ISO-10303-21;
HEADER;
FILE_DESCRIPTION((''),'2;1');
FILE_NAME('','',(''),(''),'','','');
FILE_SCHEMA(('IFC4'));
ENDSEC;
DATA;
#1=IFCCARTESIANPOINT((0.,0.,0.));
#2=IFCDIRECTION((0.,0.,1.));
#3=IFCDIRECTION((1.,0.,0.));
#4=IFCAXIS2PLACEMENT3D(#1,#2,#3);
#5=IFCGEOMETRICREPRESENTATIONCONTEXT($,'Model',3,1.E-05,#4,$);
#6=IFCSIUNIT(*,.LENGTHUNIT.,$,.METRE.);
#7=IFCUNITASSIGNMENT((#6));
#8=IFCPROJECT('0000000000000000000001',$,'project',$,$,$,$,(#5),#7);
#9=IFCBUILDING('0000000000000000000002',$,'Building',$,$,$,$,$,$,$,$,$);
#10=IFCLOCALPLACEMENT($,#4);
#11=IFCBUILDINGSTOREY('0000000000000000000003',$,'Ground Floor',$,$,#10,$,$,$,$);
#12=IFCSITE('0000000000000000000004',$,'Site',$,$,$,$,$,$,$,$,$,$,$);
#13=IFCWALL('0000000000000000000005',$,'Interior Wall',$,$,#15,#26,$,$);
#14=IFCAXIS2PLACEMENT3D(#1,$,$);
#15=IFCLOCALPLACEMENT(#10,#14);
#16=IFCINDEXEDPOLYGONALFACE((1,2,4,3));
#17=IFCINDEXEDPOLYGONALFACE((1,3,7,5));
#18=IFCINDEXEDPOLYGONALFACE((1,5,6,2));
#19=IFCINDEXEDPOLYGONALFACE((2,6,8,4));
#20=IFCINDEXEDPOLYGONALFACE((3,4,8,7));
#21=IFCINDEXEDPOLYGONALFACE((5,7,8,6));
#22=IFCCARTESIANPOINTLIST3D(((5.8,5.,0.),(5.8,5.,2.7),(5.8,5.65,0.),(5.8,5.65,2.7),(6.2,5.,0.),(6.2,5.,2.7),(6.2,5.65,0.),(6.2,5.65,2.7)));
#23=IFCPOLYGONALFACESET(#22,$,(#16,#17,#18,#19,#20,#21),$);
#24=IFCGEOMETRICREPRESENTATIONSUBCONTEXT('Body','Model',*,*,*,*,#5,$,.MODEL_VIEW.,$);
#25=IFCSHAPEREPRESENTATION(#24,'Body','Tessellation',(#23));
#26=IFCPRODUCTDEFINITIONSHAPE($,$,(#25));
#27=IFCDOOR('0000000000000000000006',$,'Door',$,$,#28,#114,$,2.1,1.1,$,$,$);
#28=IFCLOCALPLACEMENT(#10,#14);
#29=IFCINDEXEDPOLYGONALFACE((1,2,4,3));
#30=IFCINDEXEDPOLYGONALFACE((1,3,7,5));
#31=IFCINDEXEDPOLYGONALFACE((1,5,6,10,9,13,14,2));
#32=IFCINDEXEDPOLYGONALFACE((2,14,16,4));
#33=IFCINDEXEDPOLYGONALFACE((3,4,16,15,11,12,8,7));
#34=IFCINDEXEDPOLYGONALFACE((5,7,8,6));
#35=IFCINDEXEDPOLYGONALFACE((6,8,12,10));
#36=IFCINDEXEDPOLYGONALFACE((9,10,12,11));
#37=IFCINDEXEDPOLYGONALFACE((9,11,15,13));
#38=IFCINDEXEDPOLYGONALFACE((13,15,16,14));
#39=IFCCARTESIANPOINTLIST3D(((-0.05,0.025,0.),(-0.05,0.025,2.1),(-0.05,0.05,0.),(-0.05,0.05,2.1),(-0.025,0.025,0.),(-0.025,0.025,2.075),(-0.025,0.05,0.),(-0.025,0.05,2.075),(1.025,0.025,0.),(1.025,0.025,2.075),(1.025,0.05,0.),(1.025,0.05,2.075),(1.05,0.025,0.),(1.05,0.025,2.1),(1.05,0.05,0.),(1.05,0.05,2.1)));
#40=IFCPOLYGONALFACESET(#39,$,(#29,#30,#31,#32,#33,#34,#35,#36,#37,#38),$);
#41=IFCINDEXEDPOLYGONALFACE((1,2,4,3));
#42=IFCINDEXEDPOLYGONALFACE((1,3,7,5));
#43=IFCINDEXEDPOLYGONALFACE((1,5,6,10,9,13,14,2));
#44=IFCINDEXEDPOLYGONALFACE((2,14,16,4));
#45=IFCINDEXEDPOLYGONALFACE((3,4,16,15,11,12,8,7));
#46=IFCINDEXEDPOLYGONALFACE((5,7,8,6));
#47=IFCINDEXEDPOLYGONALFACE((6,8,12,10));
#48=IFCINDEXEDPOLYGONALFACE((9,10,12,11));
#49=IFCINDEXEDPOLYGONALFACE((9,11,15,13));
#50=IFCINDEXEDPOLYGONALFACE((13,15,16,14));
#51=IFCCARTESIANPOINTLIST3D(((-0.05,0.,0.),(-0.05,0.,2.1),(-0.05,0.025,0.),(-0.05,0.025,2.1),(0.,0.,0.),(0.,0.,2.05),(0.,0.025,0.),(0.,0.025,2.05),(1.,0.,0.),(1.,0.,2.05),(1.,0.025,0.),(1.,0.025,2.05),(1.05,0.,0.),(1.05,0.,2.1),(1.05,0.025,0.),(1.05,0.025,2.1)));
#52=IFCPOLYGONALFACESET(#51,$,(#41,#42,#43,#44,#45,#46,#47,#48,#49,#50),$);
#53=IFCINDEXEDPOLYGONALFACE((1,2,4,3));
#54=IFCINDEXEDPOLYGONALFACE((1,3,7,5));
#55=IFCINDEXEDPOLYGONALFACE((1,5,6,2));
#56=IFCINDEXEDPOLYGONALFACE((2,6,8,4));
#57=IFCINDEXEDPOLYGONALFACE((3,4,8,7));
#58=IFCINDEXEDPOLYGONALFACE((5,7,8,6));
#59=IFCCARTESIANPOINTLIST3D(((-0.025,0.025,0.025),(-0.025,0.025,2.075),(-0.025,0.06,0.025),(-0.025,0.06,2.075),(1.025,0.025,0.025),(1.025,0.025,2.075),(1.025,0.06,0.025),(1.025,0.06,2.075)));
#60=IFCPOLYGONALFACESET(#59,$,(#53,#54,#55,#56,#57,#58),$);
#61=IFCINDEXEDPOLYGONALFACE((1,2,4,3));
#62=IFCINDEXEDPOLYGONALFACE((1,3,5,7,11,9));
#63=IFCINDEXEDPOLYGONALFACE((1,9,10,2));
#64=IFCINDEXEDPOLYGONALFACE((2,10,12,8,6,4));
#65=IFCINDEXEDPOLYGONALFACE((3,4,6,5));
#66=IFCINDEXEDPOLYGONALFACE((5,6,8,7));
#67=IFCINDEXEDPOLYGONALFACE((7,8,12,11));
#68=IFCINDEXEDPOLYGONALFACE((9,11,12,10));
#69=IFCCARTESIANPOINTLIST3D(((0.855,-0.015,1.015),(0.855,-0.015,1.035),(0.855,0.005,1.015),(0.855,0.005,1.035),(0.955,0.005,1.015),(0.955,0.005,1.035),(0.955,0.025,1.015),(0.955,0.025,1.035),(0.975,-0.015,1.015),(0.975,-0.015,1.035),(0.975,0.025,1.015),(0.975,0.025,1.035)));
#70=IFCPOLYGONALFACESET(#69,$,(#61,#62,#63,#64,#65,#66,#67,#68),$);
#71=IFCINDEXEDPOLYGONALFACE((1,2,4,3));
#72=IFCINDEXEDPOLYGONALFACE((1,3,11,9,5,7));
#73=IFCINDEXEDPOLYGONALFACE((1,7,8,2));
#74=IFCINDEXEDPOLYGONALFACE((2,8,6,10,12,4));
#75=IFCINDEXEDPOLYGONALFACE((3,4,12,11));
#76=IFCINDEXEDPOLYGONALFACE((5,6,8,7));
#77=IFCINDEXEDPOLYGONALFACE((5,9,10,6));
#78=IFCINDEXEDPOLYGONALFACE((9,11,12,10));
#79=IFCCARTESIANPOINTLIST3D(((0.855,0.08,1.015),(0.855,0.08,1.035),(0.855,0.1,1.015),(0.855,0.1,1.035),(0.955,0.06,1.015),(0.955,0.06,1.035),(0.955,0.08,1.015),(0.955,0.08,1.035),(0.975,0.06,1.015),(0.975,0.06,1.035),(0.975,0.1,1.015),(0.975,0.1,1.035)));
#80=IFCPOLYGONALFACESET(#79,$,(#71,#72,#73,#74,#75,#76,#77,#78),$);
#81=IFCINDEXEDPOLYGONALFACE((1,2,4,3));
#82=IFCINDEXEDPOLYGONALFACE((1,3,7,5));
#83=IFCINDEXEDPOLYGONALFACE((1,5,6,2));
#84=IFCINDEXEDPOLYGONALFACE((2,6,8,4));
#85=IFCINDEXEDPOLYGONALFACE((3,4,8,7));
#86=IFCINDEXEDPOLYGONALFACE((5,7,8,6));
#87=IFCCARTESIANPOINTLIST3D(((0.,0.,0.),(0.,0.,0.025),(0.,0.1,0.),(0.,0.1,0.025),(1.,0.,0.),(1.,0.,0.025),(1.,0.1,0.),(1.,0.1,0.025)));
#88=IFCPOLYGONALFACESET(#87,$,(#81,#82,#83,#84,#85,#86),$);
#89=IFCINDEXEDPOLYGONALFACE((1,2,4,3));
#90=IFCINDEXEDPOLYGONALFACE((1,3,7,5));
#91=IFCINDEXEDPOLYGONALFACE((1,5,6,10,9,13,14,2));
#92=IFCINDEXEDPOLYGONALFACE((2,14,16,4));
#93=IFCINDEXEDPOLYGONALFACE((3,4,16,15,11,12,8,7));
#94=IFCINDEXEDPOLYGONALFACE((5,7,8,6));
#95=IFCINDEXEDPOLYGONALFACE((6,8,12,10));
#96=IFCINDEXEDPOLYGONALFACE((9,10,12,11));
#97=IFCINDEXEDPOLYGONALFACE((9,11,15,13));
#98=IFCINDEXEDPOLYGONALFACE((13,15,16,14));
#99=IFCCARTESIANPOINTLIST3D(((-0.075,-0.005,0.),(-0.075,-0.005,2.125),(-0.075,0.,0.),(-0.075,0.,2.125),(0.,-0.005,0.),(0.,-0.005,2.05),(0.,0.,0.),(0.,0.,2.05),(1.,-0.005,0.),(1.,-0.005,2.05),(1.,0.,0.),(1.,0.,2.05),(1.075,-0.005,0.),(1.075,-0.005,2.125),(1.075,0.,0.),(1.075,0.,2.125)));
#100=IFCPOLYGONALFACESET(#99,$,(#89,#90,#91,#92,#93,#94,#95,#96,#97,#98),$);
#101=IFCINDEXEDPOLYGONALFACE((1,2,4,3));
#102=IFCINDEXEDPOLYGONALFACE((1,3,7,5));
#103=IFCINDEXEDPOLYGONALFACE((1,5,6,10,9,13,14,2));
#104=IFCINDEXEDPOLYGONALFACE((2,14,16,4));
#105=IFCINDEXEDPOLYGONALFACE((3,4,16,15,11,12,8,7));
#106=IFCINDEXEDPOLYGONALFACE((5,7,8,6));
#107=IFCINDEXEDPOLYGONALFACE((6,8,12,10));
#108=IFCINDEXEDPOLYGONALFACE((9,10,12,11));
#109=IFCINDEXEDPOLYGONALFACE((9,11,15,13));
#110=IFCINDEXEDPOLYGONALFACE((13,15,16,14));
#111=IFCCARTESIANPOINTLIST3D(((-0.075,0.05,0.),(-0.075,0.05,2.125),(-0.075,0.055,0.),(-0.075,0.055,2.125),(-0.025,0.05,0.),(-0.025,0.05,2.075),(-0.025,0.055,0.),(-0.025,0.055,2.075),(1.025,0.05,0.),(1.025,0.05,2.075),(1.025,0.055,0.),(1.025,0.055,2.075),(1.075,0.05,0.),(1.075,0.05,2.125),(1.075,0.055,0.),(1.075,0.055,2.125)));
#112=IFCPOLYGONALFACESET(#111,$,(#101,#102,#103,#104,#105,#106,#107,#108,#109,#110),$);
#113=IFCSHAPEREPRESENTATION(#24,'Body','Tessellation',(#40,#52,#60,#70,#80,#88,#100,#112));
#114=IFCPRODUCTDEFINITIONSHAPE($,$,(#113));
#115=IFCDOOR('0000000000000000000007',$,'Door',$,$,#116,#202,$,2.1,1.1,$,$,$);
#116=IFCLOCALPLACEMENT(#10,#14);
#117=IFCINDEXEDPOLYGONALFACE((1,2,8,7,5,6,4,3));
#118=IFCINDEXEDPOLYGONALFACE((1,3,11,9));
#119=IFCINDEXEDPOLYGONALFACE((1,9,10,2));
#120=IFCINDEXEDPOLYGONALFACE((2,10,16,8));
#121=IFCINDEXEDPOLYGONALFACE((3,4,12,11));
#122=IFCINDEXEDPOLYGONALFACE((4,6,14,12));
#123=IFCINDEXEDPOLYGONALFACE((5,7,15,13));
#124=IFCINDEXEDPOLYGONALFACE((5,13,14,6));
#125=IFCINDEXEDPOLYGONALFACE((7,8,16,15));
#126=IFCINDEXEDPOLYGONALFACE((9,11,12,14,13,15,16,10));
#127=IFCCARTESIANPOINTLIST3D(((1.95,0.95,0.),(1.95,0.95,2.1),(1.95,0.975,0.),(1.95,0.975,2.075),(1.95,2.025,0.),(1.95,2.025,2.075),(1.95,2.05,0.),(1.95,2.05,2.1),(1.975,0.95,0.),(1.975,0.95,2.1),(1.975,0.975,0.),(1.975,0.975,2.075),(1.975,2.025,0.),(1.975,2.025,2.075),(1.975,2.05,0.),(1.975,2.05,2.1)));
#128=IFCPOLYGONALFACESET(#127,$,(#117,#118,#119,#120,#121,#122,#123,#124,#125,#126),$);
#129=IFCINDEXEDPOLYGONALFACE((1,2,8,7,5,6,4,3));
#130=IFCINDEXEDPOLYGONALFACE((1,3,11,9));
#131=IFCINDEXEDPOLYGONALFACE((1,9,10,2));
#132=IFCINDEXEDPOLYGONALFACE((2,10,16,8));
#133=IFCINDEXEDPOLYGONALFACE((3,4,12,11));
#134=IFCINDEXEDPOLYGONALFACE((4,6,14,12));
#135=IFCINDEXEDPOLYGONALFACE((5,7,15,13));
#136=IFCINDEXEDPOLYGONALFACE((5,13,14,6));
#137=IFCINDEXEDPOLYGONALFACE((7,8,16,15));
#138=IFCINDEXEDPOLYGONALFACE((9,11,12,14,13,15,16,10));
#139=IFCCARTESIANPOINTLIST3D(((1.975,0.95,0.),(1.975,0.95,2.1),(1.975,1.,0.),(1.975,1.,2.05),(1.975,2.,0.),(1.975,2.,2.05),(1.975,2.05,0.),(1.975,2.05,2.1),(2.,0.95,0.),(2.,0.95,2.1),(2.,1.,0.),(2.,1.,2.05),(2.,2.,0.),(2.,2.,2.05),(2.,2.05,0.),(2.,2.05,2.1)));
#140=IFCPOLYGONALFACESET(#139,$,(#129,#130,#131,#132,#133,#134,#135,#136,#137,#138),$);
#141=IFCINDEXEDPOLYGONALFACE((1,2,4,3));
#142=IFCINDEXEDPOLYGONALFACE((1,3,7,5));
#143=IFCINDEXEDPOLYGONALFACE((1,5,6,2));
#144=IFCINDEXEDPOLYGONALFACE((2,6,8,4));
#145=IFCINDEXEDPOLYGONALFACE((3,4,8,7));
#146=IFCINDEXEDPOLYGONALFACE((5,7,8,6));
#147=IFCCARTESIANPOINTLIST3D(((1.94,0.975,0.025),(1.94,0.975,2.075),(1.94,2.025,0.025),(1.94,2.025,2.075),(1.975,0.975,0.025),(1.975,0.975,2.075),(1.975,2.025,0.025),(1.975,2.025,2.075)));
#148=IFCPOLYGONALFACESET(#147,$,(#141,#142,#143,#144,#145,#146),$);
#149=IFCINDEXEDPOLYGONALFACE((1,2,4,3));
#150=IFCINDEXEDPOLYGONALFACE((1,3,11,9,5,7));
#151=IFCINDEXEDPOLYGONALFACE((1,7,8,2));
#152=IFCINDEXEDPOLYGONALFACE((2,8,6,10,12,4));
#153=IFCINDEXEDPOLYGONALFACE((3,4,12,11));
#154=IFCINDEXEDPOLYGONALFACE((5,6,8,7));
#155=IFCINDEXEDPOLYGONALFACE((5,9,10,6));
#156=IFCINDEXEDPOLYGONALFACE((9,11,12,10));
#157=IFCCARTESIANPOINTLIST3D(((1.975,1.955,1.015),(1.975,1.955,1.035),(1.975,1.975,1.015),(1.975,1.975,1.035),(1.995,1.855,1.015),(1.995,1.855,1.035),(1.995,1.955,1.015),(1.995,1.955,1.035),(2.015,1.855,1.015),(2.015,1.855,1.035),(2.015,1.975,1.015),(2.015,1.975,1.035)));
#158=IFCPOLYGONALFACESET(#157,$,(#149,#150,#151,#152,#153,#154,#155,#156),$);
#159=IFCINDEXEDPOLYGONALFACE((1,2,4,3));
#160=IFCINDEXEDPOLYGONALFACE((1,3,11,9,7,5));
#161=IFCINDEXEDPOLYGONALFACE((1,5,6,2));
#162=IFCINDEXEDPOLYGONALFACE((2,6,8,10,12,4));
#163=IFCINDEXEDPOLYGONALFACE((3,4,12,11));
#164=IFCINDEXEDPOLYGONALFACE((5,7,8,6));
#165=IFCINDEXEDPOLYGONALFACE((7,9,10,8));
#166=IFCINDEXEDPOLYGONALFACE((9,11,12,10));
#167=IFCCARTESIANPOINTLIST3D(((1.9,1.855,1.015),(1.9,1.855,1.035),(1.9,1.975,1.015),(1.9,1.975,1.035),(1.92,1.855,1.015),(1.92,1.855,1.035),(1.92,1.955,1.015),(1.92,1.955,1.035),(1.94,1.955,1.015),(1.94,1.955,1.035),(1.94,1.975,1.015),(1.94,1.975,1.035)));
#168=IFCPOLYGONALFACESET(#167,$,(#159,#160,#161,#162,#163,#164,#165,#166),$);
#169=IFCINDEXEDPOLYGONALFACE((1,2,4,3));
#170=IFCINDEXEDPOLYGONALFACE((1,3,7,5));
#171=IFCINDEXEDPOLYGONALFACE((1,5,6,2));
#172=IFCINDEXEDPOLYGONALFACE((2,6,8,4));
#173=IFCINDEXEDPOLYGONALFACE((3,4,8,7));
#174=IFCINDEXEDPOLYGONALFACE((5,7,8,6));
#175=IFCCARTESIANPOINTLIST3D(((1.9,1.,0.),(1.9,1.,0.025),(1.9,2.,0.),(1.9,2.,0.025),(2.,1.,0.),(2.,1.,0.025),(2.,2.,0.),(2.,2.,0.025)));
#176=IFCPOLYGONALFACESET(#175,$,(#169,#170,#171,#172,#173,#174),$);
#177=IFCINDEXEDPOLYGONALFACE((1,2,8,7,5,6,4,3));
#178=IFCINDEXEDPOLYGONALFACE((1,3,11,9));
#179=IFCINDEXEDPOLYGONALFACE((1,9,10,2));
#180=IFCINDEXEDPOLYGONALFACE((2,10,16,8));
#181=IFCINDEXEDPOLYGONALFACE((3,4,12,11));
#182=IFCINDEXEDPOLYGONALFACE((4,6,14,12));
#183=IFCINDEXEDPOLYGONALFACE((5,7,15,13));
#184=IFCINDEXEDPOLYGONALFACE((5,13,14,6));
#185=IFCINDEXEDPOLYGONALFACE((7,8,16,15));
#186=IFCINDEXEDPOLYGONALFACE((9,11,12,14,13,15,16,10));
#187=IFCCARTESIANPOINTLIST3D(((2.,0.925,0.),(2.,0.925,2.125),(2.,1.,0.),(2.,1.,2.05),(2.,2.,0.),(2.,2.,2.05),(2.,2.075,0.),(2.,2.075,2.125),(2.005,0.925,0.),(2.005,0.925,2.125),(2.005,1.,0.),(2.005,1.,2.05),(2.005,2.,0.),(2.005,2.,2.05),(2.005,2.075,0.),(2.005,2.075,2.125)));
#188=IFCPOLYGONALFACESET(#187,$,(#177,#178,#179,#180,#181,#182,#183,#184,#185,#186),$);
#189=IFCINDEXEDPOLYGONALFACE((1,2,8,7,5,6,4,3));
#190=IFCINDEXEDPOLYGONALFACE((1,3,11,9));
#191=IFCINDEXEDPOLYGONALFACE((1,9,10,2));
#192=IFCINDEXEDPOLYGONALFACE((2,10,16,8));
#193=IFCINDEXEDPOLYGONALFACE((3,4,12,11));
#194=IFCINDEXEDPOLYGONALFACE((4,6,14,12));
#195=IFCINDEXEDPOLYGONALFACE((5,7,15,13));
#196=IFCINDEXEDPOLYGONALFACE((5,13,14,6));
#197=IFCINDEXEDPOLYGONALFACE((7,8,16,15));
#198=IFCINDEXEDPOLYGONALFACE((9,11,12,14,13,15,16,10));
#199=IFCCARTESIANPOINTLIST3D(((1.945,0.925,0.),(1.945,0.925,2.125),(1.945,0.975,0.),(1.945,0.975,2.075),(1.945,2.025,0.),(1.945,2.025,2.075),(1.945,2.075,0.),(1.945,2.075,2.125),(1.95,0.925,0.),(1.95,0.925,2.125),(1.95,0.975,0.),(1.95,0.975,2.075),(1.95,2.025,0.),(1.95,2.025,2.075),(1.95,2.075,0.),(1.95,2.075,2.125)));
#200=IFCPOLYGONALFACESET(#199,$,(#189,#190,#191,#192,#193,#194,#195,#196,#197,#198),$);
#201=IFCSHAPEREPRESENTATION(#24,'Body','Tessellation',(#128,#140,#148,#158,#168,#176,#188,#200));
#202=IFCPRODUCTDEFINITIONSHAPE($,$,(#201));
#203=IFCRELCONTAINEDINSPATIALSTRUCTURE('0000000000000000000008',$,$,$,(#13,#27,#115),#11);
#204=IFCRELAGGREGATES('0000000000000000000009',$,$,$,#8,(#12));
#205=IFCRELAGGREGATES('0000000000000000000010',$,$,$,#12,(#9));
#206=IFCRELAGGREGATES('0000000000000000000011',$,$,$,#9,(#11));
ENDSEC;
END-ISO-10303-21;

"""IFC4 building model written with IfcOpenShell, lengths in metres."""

from ifc_helpers import new_model, si_unit, frame, origin_with_axes, place, context, subcontext, project, spatial, line, indexed_curve, outline, extrude, element, save


model = new_model("IFC4")

# Units and contexts
model_context = context("Model", 3, precision=1e-05, world=origin_with_axes())
body_context = subcontext(model_context, "Body", "Model", "MODEL_VIEW")
ifc_project = project(units=[si_unit("LENGTHUNIT", "METRE")], contexts=[model_context])

# Site, building, storey
site = spatial("IfcSite", under=ifc_project, Name="Site")
building = spatial("IfcBuilding", under=site, Name="Building")
storey_placement = place(None, origin_with_axes())
storey = spatial("IfcBuildingStorey", under=building, at=storey_placement, Name="Ground Floor")

# Wall
wall_1_placement = place(storey_placement, frame((6.0, 5.0, 0.0), z_axis=(0.0, 0.0, 1.0), x_axis=(0.0, 1.0, 0.0)))
element("IfcWall", 1, at=wall_1_placement, inside=storey, Name="Interior Wall", context=body_context, shape_type="SweptSolid", body=[
    extrude(outline(indexed_curve([(0.0, 0.0), (0.0, 0.4), (0.65, 0.4), (0.65, 0.0), (0.0, 0.0)], self_intersect=False)), frame((0.0, -0.2, 0.0), z_axis=(0.0, 0.0, 1.0), x_axis=(1.0, 0.0, 0.0)), (0.0, 0.0, 1.0), 2.7),
])

# Doors
door_1_placement = place(storey_placement, frame((-0.05, 0.0, 0.0), z_axis=(0.0, 0.0, 1.0), x_axis=(1.0, 0.0, 0.0)))
element("IfcDoor", 2, at=door_1_placement, inside=storey, Name="Door", OverallHeight=2.1, OverallWidth=1.1, context=body_context, shape_type="SweptSolid", body=[
    extrude(outline(indexed_curve([(0.0, 0.0), (0.0, 2.1), (1.1, 2.1), (1.1, 0.0), (1.075, 0.0), (1.075, 2.075), (0.025, 2.075), (0.025, 0.0)], segments=[line(1, 2, 3, 4, 5, 6, 7, 8, 1)])), frame((0.0, 0.025, 0.0), z_axis=(0.0, -1.0, 0.0), x_axis=(1.0, 0.0, 0.0)), (0.0, 0.0, -1.0), 0.025),
    extrude(outline(indexed_curve([(0.0, 0.0), (0.0, 2.1), (1.1, 2.1), (1.1, 0.0), (1.05, 0.0), (1.05, 2.05), (0.05, 2.05), (0.05, 0.0)], segments=[line(1, 2, 3, 4, 5, 6, 7, 8, 1)])), frame((0.0, 0.0, 0.0), z_axis=(0.0, -1.0, 0.0), x_axis=(1.0, 0.0, 0.0)), (0.0, 0.0, -1.0), 0.025),
    extrude(outline(indexed_curve([(0.0, 0.0), (1.05, 0.0), (1.05, 0.035), (0.0, 0.035)], segments=[line(1, 2, 3, 4, 1)])), frame((0.025, 0.025, 0.025), z_axis=(0.0, 0.0, 1.0), x_axis=(1.0, 0.0, 0.0)), (0.0, 0.0, 1.0), 2.05),
    extrude(outline(indexed_curve([(0.0, 0.0), (0.0, -0.04), (-0.12, -0.04), (-0.12, -0.02), (-0.02, -0.02), (-0.02, 0.0)], segments=[line(1, 2, 3, 4, 5, 6, 1)])), frame((1.025, 0.025, 1.015), z_axis=(0.0, 0.0, 1.0), x_axis=(1.0, 0.0, 0.0)), (0.0, 0.0, 1.0), 0.02),
    extrude(outline(indexed_curve([(0.0, 0.0), (0.0, 0.04), (-0.12, 0.04), (-0.12, 0.02), (-0.02, 0.02), (-0.02, 0.0)], segments=[line(1, 2, 3, 4, 5, 6, 1)])), frame((1.025, 0.06, 1.015), z_axis=(0.0, 0.0, 1.0), x_axis=(1.0, 0.0, 0.0)), (0.0, 0.0, 1.0), 0.02),
    extrude(outline(indexed_curve([(0.0, 0.0), (1.0, 0.0), (1.0, 0.1), (0.0, 0.1)], segments=[line(1, 2, 3, 4, 1)])), frame((0.05, 0.0, 0.0), z_axis=(0.0, 0.0, 1.0), x_axis=(1.0, 0.0, 0.0)), (0.0, 0.0, 1.0), 0.025),
    extrude(outline(indexed_curve([(0.0, 0.0), (0.0, 2.125), (1.15, 2.125), (1.15, 0.0), (1.075, 0.0), (1.075, 2.05), (0.075, 2.05), (0.075, 0.0)], segments=[line(1, 2, 3, 4, 5, 6, 7, 8, 1)])), frame((-0.025, -0.005, 0.0), z_axis=(0.0, -1.0, 0.0), x_axis=(1.0, 0.0, 0.0)), (0.0, 0.0, -1.0), 0.005),
    extrude(outline(indexed_curve([(0.0, 0.0), (0.0, 2.125), (1.15, 2.125), (1.15, 0.0), (1.1, 0.0), (1.1, 2.075), (0.05, 2.075), (0.05, 0.0)], segments=[line(1, 2, 3, 4, 5, 6, 7, 8, 1)])), frame((-0.025, 0.05, 0.0), z_axis=(0.0, -1.0, 0.0), x_axis=(1.0, 0.0, 0.0)), (0.0, 0.0, -1.0), 0.005),
])
door_2_placement = place(storey_placement, frame((2.0, 0.95, 0.0), z_axis=(0.0, 0.0, 1.0), x_axis=(0.0, 1.0, 0.0)))
element("IfcDoor", 3, at=door_2_placement, inside=storey, Name="Door", OverallHeight=2.1, OverallWidth=1.1, context=body_context, shape_type="SweptSolid", body=[
    extrude(outline(indexed_curve([(0.0, 0.0), (0.0, 2.1), (1.1, 2.1), (1.1, 0.0), (1.075, 0.0), (1.075, 2.075), (0.025, 2.075), (0.025, 0.0)], segments=[line(1, 2, 3, 4, 5, 6, 7, 8, 1)])), frame((0.0, 0.025, 0.0), z_axis=(0.0, -1.0, 0.0), x_axis=(1.0, 0.0, 0.0)), (0.0, 0.0, -1.0), 0.025),
    extrude(outline(indexed_curve([(0.0, 0.0), (0.0, 2.1), (1.1, 2.1), (1.1, 0.0), (1.05, 0.0), (1.05, 2.05), (0.05, 2.05), (0.05, 0.0)], segments=[line(1, 2, 3, 4, 5, 6, 7, 8, 1)])), frame((0.0, 0.0, 0.0), z_axis=(0.0, -1.0, 0.0), x_axis=(1.0, 0.0, 0.0)), (0.0, 0.0, -1.0), 0.025),
    extrude(outline(indexed_curve([(0.0, 0.0), (1.05, 0.0), (1.05, 0.035), (0.0, 0.035)], segments=[line(1, 2, 3, 4, 1)])), frame((0.025, 0.025, 0.025), z_axis=(0.0, 0.0, 1.0), x_axis=(1.0, 0.0, 0.0)), (0.0, 0.0, 1.0), 2.05),
    extrude(outline(indexed_curve([(0.0, 0.0), (0.0, -0.04), (-0.12, -0.04), (-0.12, -0.02), (-0.02, -0.02), (-0.02, 0.0)], segments=[line(1, 2, 3, 4, 5, 6, 1)])), frame((1.025, 0.025, 1.015), z_axis=(0.0, 0.0, 1.0), x_axis=(1.0, 0.0, 0.0)), (0.0, 0.0, 1.0), 0.02),
    extrude(outline(indexed_curve([(0.0, 0.0), (0.0, 0.04), (-0.12, 0.04), (-0.12, 0.02), (-0.02, 0.02), (-0.02, 0.0)], segments=[line(1, 2, 3, 4, 5, 6, 1)])), frame((1.025, 0.06, 1.015), z_axis=(0.0, 0.0, 1.0), x_axis=(1.0, 0.0, 0.0)), (0.0, 0.0, 1.0), 0.02),
    extrude(outline(indexed_curve([(0.0, 0.0), (1.0, 0.0), (1.0, 0.1), (0.0, 0.1)], segments=[line(1, 2, 3, 4, 1)])), frame((0.05, 0.0, 0.0), z_axis=(0.0, 0.0, 1.0), x_axis=(1.0, 0.0, 0.0)), (0.0, 0.0, 1.0), 0.025),
    extrude(outline(indexed_curve([(0.0, 0.0), (0.0, 2.125), (1.15, 2.125), (1.15, 0.0), (1.075, 0.0), (1.075, 2.05), (0.075, 2.05), (0.075, 0.0)], segments=[line(1, 2, 3, 4, 5, 6, 7, 8, 1)])), frame((-0.025, -0.005, 0.0), z_axis=(0.0, -1.0, 0.0), x_axis=(1.0, 0.0, 0.0)), (0.0, 0.0, -1.0), 0.005),
    extrude(outline(indexed_curve([(0.0, 0.0), (0.0, 2.125), (1.15, 2.125), (1.15, 0.0), (1.1, 0.0), (1.1, 2.075), (0.05, 2.075), (0.05, 0.0)], segments=[line(1, 2, 3, 4, 5, 6, 7, 8, 1)])), frame((-0.025, 0.05, 0.0), z_axis=(0.0, -1.0, 0.0), x_axis=(1.0, 0.0, 0.0)), (0.0, 0.0, -1.0), 0.005),
])

save(model, "model.ifc")
